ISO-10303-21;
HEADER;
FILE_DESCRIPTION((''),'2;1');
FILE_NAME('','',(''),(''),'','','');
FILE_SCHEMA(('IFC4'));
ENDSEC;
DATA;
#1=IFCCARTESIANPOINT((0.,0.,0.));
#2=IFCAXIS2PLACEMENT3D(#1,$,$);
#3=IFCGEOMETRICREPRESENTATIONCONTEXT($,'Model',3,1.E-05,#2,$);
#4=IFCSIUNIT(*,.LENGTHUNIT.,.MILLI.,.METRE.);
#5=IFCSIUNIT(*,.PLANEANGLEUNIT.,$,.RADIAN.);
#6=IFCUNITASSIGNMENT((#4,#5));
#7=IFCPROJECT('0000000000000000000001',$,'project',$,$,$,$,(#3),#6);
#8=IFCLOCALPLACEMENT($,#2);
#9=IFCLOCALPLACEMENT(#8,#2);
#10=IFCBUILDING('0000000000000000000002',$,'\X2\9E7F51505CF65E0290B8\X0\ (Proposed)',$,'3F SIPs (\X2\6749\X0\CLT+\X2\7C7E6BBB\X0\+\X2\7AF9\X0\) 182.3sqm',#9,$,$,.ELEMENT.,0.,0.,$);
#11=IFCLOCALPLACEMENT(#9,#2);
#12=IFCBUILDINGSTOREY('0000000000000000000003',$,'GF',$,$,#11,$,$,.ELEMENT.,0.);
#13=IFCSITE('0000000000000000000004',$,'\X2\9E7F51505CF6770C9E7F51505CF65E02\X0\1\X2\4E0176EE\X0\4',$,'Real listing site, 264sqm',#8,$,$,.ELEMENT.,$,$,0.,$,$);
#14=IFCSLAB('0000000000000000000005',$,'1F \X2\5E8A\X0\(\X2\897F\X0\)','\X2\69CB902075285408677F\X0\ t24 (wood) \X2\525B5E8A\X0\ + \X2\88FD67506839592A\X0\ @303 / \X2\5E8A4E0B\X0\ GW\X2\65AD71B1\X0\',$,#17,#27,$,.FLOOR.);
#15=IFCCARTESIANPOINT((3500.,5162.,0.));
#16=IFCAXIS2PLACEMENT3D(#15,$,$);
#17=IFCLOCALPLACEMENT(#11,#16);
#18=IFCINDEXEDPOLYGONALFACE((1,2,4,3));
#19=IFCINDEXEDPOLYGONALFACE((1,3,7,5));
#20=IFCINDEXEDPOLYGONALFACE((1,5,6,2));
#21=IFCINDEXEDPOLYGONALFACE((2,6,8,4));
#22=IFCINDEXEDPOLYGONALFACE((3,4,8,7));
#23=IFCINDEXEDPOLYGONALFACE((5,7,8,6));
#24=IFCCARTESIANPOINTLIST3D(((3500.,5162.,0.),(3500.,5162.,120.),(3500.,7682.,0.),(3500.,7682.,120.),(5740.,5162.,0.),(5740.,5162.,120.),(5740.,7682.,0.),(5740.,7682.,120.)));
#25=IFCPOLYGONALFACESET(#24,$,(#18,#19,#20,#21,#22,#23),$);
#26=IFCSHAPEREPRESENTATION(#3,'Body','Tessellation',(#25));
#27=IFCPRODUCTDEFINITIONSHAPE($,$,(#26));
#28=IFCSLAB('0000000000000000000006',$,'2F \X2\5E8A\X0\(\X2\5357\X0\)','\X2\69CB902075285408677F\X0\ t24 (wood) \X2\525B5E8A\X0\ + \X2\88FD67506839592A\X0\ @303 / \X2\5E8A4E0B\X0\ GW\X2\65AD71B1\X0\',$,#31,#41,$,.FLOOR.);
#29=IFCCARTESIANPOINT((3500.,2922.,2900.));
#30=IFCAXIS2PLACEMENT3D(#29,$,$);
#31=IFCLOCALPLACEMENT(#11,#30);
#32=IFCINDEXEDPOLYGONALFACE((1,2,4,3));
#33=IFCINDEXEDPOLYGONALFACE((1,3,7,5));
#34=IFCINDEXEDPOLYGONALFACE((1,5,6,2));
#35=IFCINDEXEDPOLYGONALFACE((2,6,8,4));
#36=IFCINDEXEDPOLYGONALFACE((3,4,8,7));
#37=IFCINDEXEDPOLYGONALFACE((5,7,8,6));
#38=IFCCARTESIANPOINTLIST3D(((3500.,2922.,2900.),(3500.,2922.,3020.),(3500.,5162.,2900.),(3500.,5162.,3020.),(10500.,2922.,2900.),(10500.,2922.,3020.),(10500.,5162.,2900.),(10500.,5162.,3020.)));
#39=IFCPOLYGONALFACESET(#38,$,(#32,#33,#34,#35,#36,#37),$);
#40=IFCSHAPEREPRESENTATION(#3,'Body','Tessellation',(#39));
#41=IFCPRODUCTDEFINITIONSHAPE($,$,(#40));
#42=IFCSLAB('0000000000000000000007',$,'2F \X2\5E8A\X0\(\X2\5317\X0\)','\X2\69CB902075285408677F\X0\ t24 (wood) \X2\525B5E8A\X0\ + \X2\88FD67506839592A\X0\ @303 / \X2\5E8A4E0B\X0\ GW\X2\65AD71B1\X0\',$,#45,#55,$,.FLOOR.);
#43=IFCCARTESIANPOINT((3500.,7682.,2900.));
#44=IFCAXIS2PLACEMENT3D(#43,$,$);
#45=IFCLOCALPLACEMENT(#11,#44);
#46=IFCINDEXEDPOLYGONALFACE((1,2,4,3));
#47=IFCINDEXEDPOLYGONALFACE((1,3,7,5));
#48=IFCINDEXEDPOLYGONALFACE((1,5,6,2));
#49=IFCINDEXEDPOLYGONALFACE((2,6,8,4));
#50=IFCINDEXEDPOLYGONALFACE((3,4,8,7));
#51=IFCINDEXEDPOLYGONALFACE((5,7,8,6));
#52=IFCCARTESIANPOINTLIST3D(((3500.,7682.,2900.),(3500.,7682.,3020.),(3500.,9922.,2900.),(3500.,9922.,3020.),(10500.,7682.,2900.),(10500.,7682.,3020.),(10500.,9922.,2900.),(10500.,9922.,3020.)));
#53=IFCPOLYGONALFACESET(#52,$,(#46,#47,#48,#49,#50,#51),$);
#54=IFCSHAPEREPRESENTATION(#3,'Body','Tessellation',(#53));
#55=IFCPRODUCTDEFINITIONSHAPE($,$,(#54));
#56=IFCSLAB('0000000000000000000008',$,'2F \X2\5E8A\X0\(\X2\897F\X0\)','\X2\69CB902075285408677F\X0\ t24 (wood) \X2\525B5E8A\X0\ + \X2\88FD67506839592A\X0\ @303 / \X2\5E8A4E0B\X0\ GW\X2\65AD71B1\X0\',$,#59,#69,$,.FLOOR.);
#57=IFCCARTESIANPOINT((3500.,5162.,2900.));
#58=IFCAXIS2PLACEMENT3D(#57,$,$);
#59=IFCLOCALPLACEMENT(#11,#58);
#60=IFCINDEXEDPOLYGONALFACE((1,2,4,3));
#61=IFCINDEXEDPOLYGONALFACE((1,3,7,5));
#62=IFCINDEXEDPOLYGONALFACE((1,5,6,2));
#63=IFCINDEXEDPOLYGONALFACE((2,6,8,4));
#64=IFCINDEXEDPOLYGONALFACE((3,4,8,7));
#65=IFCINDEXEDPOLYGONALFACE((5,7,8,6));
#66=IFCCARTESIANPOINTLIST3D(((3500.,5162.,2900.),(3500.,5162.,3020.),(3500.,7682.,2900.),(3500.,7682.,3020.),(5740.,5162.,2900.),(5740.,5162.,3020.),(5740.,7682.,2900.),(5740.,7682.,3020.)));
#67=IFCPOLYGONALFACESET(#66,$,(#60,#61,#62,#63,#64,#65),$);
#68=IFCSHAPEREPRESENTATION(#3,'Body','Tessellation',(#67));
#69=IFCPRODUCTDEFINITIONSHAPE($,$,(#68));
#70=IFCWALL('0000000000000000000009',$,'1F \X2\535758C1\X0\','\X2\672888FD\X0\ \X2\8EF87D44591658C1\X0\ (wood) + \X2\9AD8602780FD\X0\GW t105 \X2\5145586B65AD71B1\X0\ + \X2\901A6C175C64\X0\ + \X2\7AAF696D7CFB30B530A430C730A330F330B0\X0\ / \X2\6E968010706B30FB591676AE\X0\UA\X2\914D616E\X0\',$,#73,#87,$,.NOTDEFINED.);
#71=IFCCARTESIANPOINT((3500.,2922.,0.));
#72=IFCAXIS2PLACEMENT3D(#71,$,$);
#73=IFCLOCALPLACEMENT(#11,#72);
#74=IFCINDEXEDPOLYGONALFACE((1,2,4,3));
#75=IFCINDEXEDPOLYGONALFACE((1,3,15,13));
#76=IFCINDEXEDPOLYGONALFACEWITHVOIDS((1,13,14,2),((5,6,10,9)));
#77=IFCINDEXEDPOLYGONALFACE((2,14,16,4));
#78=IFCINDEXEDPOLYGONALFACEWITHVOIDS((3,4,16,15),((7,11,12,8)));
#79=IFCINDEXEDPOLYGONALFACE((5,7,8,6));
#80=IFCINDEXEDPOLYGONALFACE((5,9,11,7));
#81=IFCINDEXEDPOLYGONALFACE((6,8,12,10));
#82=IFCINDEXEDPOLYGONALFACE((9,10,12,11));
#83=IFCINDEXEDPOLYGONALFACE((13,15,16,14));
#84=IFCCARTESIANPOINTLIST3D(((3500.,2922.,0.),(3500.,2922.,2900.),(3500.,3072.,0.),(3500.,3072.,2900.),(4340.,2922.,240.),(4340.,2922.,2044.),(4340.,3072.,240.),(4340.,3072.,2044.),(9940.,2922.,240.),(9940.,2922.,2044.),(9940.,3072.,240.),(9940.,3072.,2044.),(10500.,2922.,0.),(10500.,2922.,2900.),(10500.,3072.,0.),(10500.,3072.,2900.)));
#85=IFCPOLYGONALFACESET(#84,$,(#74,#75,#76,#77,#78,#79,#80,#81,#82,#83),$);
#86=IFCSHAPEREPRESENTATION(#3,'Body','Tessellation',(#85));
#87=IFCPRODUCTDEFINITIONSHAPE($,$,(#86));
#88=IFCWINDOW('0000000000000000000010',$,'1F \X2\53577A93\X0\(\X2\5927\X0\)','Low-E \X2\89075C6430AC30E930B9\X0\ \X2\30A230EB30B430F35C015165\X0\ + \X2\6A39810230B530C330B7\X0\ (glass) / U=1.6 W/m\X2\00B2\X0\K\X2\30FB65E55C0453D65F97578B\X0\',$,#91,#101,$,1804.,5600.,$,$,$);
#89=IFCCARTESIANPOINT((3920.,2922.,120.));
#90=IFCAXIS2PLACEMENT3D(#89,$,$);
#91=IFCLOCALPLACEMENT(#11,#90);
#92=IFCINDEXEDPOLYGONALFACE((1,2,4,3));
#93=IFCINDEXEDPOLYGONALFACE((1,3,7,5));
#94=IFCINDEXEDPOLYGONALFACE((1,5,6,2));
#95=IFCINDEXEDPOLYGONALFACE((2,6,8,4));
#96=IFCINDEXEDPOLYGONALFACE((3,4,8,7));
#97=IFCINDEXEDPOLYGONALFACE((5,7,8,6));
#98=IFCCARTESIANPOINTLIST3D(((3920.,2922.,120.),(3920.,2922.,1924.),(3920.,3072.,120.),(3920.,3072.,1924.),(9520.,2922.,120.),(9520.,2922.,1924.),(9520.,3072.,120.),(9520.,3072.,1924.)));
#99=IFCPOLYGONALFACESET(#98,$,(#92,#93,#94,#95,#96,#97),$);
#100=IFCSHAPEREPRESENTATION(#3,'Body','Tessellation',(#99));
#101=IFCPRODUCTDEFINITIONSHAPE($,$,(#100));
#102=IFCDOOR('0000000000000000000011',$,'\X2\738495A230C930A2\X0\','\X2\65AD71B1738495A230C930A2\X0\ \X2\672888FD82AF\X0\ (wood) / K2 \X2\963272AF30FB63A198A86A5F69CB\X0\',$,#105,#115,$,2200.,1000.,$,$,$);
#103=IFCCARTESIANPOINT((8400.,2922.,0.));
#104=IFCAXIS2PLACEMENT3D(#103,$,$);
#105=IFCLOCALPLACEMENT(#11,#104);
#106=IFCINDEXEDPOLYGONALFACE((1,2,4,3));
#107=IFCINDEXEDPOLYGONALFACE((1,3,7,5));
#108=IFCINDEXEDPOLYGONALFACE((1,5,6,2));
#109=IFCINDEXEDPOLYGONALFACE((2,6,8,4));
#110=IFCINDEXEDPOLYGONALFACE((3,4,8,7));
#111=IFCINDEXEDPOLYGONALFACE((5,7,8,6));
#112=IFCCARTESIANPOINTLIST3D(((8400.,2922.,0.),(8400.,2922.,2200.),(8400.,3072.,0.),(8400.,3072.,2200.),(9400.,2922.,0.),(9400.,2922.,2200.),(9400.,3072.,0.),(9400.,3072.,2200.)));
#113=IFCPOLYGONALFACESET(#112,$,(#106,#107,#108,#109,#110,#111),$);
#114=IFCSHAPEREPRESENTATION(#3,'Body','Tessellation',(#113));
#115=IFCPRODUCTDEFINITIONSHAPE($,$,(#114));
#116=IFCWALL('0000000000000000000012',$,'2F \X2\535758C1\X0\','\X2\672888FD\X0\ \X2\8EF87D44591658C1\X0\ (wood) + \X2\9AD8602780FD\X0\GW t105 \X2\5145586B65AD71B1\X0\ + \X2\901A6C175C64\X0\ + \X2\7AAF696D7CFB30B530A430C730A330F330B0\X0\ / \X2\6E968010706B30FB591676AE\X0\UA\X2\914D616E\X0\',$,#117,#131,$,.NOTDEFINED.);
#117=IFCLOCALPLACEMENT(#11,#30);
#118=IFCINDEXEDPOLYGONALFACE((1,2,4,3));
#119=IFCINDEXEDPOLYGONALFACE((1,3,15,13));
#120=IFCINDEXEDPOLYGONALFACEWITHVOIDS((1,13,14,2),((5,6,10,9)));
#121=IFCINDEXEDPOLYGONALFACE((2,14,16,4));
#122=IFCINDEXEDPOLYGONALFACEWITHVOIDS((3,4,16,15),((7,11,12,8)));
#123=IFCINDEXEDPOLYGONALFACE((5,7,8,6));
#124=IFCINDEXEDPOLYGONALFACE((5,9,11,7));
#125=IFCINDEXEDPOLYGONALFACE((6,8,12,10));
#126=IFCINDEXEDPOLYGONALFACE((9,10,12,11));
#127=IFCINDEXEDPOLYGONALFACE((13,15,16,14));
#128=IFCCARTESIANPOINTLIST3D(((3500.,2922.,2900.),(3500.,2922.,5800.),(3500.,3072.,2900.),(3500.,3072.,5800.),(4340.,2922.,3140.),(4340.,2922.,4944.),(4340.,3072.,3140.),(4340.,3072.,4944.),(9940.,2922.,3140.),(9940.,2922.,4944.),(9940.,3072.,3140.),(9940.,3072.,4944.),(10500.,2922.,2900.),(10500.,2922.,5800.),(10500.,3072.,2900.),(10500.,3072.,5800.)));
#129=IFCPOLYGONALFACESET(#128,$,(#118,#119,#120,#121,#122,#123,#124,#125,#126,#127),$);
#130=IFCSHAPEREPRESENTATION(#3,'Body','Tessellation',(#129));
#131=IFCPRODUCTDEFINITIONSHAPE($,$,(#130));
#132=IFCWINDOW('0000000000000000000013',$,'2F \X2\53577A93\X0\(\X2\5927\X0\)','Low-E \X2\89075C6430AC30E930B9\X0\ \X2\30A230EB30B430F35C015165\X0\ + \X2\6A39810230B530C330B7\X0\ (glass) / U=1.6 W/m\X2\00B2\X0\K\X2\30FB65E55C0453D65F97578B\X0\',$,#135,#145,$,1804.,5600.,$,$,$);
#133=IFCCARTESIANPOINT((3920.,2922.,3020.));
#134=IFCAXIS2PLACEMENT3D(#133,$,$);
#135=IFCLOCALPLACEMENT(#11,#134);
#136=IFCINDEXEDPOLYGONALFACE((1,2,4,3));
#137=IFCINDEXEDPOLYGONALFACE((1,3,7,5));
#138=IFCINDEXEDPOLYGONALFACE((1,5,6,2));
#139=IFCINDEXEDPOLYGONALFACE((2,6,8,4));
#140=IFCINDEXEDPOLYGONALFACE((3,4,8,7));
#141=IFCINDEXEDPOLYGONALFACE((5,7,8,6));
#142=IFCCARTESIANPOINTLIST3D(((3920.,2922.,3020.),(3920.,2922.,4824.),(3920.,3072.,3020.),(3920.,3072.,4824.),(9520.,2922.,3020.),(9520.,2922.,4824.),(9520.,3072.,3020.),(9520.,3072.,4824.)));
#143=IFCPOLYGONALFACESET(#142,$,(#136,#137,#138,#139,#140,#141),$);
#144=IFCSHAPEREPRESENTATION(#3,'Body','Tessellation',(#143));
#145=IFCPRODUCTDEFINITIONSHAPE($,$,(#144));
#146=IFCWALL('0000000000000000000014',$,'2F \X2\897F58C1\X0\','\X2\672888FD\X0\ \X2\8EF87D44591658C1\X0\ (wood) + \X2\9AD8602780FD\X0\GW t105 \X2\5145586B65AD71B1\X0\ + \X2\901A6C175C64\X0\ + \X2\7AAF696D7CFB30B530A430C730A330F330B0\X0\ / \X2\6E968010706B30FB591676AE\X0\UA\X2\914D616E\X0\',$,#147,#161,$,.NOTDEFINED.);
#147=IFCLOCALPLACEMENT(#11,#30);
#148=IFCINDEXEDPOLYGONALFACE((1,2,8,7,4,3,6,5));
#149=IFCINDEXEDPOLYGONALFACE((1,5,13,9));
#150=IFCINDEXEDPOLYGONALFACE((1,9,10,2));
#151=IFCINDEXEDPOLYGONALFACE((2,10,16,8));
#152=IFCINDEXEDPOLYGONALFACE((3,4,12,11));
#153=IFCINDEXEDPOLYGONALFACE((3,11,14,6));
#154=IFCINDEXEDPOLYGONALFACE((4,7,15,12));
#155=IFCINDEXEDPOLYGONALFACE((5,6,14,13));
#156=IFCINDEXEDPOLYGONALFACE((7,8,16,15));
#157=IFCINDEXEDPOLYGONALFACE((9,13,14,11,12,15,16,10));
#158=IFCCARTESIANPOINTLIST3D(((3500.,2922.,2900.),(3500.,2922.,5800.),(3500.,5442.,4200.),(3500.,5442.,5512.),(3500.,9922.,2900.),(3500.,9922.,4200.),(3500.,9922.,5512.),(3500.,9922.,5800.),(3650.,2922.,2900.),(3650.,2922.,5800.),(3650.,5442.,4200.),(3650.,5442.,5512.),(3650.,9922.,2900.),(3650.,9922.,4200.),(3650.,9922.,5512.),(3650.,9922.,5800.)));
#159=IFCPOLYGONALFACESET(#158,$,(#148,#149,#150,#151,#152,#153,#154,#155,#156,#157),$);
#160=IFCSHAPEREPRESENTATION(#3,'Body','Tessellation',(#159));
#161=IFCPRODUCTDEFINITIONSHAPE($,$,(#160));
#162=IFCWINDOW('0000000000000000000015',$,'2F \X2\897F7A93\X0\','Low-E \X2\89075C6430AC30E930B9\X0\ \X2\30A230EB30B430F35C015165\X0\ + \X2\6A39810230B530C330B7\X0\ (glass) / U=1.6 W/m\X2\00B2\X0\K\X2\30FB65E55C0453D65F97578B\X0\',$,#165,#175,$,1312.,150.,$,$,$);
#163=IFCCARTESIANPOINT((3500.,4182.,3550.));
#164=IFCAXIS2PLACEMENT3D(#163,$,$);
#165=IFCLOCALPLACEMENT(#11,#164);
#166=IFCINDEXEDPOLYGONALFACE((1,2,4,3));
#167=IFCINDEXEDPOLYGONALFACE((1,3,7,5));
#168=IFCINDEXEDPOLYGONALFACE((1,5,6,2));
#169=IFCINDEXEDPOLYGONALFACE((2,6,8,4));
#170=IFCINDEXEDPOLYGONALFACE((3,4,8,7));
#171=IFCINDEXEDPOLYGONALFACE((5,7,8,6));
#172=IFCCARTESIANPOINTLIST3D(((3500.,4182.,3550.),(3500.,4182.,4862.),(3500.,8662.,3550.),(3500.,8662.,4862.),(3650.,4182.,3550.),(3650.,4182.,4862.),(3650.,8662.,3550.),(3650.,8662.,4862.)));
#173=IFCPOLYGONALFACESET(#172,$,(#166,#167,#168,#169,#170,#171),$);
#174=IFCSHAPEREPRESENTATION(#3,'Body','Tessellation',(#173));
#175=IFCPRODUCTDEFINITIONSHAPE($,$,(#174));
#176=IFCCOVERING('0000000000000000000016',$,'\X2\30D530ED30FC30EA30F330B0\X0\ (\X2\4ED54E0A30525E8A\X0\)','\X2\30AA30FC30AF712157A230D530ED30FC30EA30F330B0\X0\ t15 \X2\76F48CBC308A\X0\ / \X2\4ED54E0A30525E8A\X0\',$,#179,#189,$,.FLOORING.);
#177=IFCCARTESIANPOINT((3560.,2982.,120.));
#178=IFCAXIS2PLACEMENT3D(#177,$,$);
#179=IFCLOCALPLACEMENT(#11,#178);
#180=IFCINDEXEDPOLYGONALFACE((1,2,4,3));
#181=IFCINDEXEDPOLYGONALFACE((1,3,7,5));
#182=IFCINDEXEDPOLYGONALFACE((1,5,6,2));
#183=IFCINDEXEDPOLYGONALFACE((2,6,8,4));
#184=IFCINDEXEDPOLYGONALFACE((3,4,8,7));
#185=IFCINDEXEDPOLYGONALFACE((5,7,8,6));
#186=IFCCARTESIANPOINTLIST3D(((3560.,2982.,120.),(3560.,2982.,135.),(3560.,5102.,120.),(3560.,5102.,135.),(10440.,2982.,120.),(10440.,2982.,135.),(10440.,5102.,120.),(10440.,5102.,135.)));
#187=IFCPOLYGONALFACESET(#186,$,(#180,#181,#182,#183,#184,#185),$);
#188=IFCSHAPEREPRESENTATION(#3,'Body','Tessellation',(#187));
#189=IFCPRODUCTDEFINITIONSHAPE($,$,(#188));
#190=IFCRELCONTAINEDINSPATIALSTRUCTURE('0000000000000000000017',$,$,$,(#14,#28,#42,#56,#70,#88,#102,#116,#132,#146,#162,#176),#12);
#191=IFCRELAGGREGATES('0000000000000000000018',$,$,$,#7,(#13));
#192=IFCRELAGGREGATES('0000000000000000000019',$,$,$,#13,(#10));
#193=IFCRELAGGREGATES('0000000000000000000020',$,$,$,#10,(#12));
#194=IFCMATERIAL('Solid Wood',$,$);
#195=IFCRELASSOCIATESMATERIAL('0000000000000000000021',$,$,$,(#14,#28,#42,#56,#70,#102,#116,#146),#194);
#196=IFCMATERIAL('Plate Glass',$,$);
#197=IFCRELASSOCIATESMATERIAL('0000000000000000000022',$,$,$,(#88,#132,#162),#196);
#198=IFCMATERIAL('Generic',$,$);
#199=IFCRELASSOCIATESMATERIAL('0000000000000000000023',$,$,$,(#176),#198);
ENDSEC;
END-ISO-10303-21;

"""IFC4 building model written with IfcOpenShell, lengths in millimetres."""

from ifc_helpers import new_model, si_unit, frame, frame_2d, origin, place, context, project, spatial, rectangle, extrude, material, element, fill, save


model = new_model("IFC4")

# Units and contexts
model_context = context("Model", 3, precision=1e-05, world=origin())
ifc_project = project(units=[si_unit("LENGTHUNIT", "METRE", prefix="MILLI"), si_unit("PLANEANGLEUNIT", "RADIAN")], contexts=[model_context])

# Site, building, storey
site_placement = place(None, origin())
site = spatial("IfcSite", under=ifc_project, at=site_placement, Name="鹿児島県鹿児島市1丁目4", ObjectType="Real listing site, 264sqm", CompositionType="ELEMENT", RefElevation=0.0)
building_placement = place(site_placement, origin())
building = spatial("IfcBuilding", under=site, at=building_placement, Name="鹿児島市邸 (Proposed)", ObjectType="3F SIPs (杉CLT+籾殻+竹) 182.3sqm", CompositionType="ELEMENT", ElevationOfRefHeight=0.0, ElevationOfTerrain=0.0)
storey_placement = place(building_placement, origin())
storey = spatial("IfcBuildingStorey", under=building, at=storey_placement, Name="GF", CompositionType="ELEMENT", Elevation=0.0)

# Slabs
ifc_material_1 = material(Name="Solid Wood")
slab_1_placement = place(storey_placement, frame((3500.0, 5162.0, 0.0)))
element("IfcSlab", 1, at=slab_1_placement, inside=storey, material=ifc_material_1, Name="1F 床(西)", Description="構造用合板 t24 (wood) 剛床 + 製材根太 @303 / 床下 GW断熱", PredefinedType="FLOOR", context=model_context, shape_type="SweptSolid", body=[
    extrude(rectangle(XDim=2240.0, YDim=2520.0, at=frame_2d((1120.0, 1260.0))), frame((3500.0, 5162.0, 0.0)), (0.0, 0.0, 1.0), 120.0),
])
slab_2_placement = place(storey_placement, frame((3500.0, 2922.0, 2900.0)))
element("IfcSlab", 2, at=slab_2_placement, inside=storey, material=ifc_material_1, Name="2F 床(南)", Description="構造用合板 t24 (wood) 剛床 + 製材根太 @303 / 床下 GW断熱", PredefinedType="FLOOR", context=model_context, shape_type="SweptSolid", body=[
    extrude(rectangle(XDim=7000.0, YDim=2240.0, at=frame_2d((3500.0, 1120.0))), frame((3500.0, 2922.0, 2900.0)), (0.0, 0.0, 1.0), 120.0),
])
slab_3_placement = place(storey_placement, frame((3500.0, 7682.0, 2900.0)))
element("IfcSlab", 3, at=slab_3_placement, inside=storey, material=ifc_material_1, Name="2F 床(北)", Description="構造用合板 t24 (wood) 剛床 + 製材根太 @303 / 床下 GW断熱", PredefinedType="FLOOR", context=model_context, shape_type="SweptSolid", body=[
    extrude(rectangle(XDim=7000.0, YDim=2240.0, at=frame_2d((3500.0, 1120.0))), frame((3500.0, 7682.0, 2900.0)), (0.0, 0.0, 1.0), 120.0),
])
slab_4_placement = place(storey_placement, frame((3500.0, 5162.0, 2900.0)))
element("IfcSlab", 4, at=slab_4_placement, inside=storey, material=ifc_material_1, Name="2F 床(西)", Description="構造用合板 t24 (wood) 剛床 + 製材根太 @303 / 床下 GW断熱", PredefinedType="FLOOR", context=model_context, shape_type="SweptSolid", body=[
    extrude(rectangle(XDim=2240.0, YDim=2520.0, at=frame_2d((1120.0, 1260.0))), frame((3500.0, 5162.0, 2900.0)), (0.0, 0.0, 1.0), 120.0),
])

# Wall, openings, window, door
wall_1_placement = place(storey_placement, frame((3500.0, 2922.0, 0.0)))
wall_1 = element("IfcWall", 5, at=wall_1_placement, inside=storey, material=ifc_material_1, Name="1F 南壁", Description="木製 軸組外壁 (wood) + 高性能GW t105 充填断熱 + 通気層 + 窯業系サイディング / 準耐火・外皮UA配慮", PredefinedType="NOTDEFINED", context=model_context, shape_type="SweptSolid", body=[
    extrude(rectangle(XDim=7000.0, YDim=150.0, at=frame_2d((3500.0, 75.0))), frame((3500.0, 2922.0, 0.0)), (0.0, 0.0, 1.0), 2900.0),
])
opening_1_placement = place(storey_placement, frame((3920.0, 2922.0, 120.0)))
opening_1 = element("IfcOpeningElement", 6, at=opening_1_placement, cuts=wall_1, PredefinedType="NOTDEFINED", context=model_context, shape_type="SweptSolid", body=[
    extrude(rectangle(XDim=5600.0, YDim=150.0, at=frame_2d((2800.0, 75.0))), frame((3920.0, 2922.0, 120.0)), (0.0, 0.0, 1.0), 1804.0),
])
opening_2_placement = place(storey_placement, frame((8400.0, 2922.0, 0.0)))
opening_2 = element("IfcOpeningElement", 7, at=opening_2_placement, cuts=wall_1, PredefinedType="NOTDEFINED", context=model_context, shape_type="SweptSolid", body=[
    extrude(rectangle(XDim=1000.0, YDim=150.0, at=frame_2d((500.0, 75.0))), frame((8400.0, 2922.0, 0.0)), (0.0, 0.0, 1.0), 2200.0),
])
ifc_material_2 = material(Name="Plate Glass")
window_1_placement = place(storey_placement, frame((3920.0, 2922.0, 120.0)))
window_1 = element("IfcWindow", 8, at=window_1_placement, inside=storey, material=ifc_material_2, Name="1F 南窓(大)", Description="Low-E 複層ガラス アルゴン封入 + 樹脂サッシ (glass) / U=1.6 W/m²K・日射取得型", OverallHeight=1804.0, OverallWidth=5600.0, context=model_context, shape_type="SweptSolid", body=[
    extrude(rectangle(XDim=5600.0, YDim=150.0, at=frame_2d((2800.0, 75.0))), frame((3920.0, 2922.0, 120.0)), (0.0, 0.0, 1.0), 1804.0),
])
fill(opening_1, window_1)
door_placement = place(storey_placement, frame((8400.0, 2922.0, 0.0)))
door = element("IfcDoor", 9, at=door_placement, inside=storey, material=ifc_material_1, Name="玄関ドア", Description="断熱玄関ドア 木製芯 (wood) / K2 防犯・採風機構", OverallHeight=2200.0, OverallWidth=1000.0, context=model_context, shape_type="SweptSolid", body=[
    extrude(rectangle(XDim=1000.0, YDim=150.0, at=frame_2d((500.0, 75.0))), frame((8400.0, 2922.0, 0.0)), (0.0, 0.0, 1.0), 2200.0),
])
fill(opening_2, door)

# Wall, opening, window
wall_2_placement = place(storey_placement, frame((3500.0, 2922.0, 2900.0)))
wall_2 = element("IfcWall", 10, at=wall_2_placement, inside=storey, material=ifc_material_1, Name="2F 南壁", Description="木製 軸組外壁 (wood) + 高性能GW t105 充填断熱 + 通気層 + 窯業系サイディング / 準耐火・外皮UA配慮", PredefinedType="NOTDEFINED", context=model_context, shape_type="SweptSolid", body=[
    extrude(rectangle(XDim=7000.0, YDim=150.0, at=frame_2d((3500.0, 75.0))), frame((3500.0, 2922.0, 2900.0)), (0.0, 0.0, 1.0), 2900.0),
])
opening_3_placement = place(storey_placement, frame((3920.0, 2922.0, 3020.0)))
opening_3 = element("IfcOpeningElement", 11, at=opening_3_placement, cuts=wall_2, PredefinedType="NOTDEFINED", context=model_context, shape_type="SweptSolid", body=[
    extrude(rectangle(XDim=5600.0, YDim=150.0, at=frame_2d((2800.0, 75.0))), frame((3920.0, 2922.0, 3020.0)), (0.0, 0.0, 1.0), 1804.0),
])
window_2_placement = place(storey_placement, frame((3920.0, 2922.0, 3020.0)))
window_2 = element("IfcWindow", 12, at=window_2_placement, inside=storey, material=ifc_material_2, Name="2F 南窓(大)", Description="Low-E 複層ガラス アルゴン封入 + 樹脂サッシ (glass) / U=1.6 W/m²K・日射取得型", OverallHeight=1804.0, OverallWidth=5600.0, context=model_context, shape_type="SweptSolid", body=[
    extrude(rectangle(XDim=5600.0, YDim=150.0, at=frame_2d((2800.0, 75.0))), frame((3920.0, 2922.0, 3020.0)), (0.0, 0.0, 1.0), 1804.0),
])
fill(opening_3, window_2)

# Wall, opening, window
wall_3_placement = place(storey_placement, frame((3500.0, 2922.0, 2900.0)))
wall_3 = element("IfcWall", 13, at=wall_3_placement, inside=storey, material=ifc_material_1, Name="2F 西壁", Description="木製 軸組外壁 (wood) + 高性能GW t105 充填断熱 + 通気層 + 窯業系サイディング / 準耐火・外皮UA配慮", PredefinedType="NOTDEFINED", context=model_context, shape_type="SweptSolid", body=[
    extrude(rectangle(XDim=150.0, YDim=7000.0, at=frame_2d((75.0, 3500.0))), frame((3500.0, 2922.0, 2900.0)), (0.0, 0.0, 1.0), 2900.0),
])
opening_4_placement = place(storey_placement, frame((3500.0, 4182.0, 3550.0)))
opening_4 = element("IfcOpeningElement", 14, at=opening_4_placement, cuts=wall_3, PredefinedType="NOTDEFINED", context=model_context, shape_type="SweptSolid", body=[
    extrude(rectangle(XDim=150.0, YDim=4480.0, at=frame_2d((75.0, 2240.0))), frame((3500.0, 4182.0, 3550.0)), (0.0, 0.0, 1.0), 1312.0),
])
window_3_placement = place(storey_placement, frame((3500.0, 4182.0, 3550.0)))
window_3 = element("IfcWindow", 15, at=window_3_placement, inside=storey, material=ifc_material_2, Name="2F 西窓", Description="Low-E 複層ガラス アルゴン封入 + 樹脂サッシ (glass) / U=1.6 W/m²K・日射取得型", OverallHeight=1312.0, OverallWidth=150.0, context=model_context, shape_type="SweptSolid", body=[
    extrude(rectangle(XDim=150.0, YDim=4480.0, at=frame_2d((75.0, 2240.0))), frame((3500.0, 4182.0, 3550.0)), (0.0, 0.0, 1.0), 1312.0),
])
fill(opening_4, window_3)

# Covering
ifc_material_3 = material(Name="Generic")
covering_1_placement = place(storey_placement, frame((3560.0, 2982.0, 120.0)))
element("IfcCovering", 16, at=covering_1_placement, inside=storey, material=ifc_material_3, Name="フローリング (仕上げ床)", Description="オーク無垢フローリング t15 直貼り / 仕上げ床", PredefinedType="FLOORING", context=model_context, shape_type="SweptSolid", body=[
    extrude(rectangle(XDim=6880.0, YDim=2120.0, at=frame_2d((3440.0, 1060.0))), frame((3560.0, 2982.0, 120.0)), (0.0, 0.0, 1.0), 15.0),
])

save(model, "model.ifc")
